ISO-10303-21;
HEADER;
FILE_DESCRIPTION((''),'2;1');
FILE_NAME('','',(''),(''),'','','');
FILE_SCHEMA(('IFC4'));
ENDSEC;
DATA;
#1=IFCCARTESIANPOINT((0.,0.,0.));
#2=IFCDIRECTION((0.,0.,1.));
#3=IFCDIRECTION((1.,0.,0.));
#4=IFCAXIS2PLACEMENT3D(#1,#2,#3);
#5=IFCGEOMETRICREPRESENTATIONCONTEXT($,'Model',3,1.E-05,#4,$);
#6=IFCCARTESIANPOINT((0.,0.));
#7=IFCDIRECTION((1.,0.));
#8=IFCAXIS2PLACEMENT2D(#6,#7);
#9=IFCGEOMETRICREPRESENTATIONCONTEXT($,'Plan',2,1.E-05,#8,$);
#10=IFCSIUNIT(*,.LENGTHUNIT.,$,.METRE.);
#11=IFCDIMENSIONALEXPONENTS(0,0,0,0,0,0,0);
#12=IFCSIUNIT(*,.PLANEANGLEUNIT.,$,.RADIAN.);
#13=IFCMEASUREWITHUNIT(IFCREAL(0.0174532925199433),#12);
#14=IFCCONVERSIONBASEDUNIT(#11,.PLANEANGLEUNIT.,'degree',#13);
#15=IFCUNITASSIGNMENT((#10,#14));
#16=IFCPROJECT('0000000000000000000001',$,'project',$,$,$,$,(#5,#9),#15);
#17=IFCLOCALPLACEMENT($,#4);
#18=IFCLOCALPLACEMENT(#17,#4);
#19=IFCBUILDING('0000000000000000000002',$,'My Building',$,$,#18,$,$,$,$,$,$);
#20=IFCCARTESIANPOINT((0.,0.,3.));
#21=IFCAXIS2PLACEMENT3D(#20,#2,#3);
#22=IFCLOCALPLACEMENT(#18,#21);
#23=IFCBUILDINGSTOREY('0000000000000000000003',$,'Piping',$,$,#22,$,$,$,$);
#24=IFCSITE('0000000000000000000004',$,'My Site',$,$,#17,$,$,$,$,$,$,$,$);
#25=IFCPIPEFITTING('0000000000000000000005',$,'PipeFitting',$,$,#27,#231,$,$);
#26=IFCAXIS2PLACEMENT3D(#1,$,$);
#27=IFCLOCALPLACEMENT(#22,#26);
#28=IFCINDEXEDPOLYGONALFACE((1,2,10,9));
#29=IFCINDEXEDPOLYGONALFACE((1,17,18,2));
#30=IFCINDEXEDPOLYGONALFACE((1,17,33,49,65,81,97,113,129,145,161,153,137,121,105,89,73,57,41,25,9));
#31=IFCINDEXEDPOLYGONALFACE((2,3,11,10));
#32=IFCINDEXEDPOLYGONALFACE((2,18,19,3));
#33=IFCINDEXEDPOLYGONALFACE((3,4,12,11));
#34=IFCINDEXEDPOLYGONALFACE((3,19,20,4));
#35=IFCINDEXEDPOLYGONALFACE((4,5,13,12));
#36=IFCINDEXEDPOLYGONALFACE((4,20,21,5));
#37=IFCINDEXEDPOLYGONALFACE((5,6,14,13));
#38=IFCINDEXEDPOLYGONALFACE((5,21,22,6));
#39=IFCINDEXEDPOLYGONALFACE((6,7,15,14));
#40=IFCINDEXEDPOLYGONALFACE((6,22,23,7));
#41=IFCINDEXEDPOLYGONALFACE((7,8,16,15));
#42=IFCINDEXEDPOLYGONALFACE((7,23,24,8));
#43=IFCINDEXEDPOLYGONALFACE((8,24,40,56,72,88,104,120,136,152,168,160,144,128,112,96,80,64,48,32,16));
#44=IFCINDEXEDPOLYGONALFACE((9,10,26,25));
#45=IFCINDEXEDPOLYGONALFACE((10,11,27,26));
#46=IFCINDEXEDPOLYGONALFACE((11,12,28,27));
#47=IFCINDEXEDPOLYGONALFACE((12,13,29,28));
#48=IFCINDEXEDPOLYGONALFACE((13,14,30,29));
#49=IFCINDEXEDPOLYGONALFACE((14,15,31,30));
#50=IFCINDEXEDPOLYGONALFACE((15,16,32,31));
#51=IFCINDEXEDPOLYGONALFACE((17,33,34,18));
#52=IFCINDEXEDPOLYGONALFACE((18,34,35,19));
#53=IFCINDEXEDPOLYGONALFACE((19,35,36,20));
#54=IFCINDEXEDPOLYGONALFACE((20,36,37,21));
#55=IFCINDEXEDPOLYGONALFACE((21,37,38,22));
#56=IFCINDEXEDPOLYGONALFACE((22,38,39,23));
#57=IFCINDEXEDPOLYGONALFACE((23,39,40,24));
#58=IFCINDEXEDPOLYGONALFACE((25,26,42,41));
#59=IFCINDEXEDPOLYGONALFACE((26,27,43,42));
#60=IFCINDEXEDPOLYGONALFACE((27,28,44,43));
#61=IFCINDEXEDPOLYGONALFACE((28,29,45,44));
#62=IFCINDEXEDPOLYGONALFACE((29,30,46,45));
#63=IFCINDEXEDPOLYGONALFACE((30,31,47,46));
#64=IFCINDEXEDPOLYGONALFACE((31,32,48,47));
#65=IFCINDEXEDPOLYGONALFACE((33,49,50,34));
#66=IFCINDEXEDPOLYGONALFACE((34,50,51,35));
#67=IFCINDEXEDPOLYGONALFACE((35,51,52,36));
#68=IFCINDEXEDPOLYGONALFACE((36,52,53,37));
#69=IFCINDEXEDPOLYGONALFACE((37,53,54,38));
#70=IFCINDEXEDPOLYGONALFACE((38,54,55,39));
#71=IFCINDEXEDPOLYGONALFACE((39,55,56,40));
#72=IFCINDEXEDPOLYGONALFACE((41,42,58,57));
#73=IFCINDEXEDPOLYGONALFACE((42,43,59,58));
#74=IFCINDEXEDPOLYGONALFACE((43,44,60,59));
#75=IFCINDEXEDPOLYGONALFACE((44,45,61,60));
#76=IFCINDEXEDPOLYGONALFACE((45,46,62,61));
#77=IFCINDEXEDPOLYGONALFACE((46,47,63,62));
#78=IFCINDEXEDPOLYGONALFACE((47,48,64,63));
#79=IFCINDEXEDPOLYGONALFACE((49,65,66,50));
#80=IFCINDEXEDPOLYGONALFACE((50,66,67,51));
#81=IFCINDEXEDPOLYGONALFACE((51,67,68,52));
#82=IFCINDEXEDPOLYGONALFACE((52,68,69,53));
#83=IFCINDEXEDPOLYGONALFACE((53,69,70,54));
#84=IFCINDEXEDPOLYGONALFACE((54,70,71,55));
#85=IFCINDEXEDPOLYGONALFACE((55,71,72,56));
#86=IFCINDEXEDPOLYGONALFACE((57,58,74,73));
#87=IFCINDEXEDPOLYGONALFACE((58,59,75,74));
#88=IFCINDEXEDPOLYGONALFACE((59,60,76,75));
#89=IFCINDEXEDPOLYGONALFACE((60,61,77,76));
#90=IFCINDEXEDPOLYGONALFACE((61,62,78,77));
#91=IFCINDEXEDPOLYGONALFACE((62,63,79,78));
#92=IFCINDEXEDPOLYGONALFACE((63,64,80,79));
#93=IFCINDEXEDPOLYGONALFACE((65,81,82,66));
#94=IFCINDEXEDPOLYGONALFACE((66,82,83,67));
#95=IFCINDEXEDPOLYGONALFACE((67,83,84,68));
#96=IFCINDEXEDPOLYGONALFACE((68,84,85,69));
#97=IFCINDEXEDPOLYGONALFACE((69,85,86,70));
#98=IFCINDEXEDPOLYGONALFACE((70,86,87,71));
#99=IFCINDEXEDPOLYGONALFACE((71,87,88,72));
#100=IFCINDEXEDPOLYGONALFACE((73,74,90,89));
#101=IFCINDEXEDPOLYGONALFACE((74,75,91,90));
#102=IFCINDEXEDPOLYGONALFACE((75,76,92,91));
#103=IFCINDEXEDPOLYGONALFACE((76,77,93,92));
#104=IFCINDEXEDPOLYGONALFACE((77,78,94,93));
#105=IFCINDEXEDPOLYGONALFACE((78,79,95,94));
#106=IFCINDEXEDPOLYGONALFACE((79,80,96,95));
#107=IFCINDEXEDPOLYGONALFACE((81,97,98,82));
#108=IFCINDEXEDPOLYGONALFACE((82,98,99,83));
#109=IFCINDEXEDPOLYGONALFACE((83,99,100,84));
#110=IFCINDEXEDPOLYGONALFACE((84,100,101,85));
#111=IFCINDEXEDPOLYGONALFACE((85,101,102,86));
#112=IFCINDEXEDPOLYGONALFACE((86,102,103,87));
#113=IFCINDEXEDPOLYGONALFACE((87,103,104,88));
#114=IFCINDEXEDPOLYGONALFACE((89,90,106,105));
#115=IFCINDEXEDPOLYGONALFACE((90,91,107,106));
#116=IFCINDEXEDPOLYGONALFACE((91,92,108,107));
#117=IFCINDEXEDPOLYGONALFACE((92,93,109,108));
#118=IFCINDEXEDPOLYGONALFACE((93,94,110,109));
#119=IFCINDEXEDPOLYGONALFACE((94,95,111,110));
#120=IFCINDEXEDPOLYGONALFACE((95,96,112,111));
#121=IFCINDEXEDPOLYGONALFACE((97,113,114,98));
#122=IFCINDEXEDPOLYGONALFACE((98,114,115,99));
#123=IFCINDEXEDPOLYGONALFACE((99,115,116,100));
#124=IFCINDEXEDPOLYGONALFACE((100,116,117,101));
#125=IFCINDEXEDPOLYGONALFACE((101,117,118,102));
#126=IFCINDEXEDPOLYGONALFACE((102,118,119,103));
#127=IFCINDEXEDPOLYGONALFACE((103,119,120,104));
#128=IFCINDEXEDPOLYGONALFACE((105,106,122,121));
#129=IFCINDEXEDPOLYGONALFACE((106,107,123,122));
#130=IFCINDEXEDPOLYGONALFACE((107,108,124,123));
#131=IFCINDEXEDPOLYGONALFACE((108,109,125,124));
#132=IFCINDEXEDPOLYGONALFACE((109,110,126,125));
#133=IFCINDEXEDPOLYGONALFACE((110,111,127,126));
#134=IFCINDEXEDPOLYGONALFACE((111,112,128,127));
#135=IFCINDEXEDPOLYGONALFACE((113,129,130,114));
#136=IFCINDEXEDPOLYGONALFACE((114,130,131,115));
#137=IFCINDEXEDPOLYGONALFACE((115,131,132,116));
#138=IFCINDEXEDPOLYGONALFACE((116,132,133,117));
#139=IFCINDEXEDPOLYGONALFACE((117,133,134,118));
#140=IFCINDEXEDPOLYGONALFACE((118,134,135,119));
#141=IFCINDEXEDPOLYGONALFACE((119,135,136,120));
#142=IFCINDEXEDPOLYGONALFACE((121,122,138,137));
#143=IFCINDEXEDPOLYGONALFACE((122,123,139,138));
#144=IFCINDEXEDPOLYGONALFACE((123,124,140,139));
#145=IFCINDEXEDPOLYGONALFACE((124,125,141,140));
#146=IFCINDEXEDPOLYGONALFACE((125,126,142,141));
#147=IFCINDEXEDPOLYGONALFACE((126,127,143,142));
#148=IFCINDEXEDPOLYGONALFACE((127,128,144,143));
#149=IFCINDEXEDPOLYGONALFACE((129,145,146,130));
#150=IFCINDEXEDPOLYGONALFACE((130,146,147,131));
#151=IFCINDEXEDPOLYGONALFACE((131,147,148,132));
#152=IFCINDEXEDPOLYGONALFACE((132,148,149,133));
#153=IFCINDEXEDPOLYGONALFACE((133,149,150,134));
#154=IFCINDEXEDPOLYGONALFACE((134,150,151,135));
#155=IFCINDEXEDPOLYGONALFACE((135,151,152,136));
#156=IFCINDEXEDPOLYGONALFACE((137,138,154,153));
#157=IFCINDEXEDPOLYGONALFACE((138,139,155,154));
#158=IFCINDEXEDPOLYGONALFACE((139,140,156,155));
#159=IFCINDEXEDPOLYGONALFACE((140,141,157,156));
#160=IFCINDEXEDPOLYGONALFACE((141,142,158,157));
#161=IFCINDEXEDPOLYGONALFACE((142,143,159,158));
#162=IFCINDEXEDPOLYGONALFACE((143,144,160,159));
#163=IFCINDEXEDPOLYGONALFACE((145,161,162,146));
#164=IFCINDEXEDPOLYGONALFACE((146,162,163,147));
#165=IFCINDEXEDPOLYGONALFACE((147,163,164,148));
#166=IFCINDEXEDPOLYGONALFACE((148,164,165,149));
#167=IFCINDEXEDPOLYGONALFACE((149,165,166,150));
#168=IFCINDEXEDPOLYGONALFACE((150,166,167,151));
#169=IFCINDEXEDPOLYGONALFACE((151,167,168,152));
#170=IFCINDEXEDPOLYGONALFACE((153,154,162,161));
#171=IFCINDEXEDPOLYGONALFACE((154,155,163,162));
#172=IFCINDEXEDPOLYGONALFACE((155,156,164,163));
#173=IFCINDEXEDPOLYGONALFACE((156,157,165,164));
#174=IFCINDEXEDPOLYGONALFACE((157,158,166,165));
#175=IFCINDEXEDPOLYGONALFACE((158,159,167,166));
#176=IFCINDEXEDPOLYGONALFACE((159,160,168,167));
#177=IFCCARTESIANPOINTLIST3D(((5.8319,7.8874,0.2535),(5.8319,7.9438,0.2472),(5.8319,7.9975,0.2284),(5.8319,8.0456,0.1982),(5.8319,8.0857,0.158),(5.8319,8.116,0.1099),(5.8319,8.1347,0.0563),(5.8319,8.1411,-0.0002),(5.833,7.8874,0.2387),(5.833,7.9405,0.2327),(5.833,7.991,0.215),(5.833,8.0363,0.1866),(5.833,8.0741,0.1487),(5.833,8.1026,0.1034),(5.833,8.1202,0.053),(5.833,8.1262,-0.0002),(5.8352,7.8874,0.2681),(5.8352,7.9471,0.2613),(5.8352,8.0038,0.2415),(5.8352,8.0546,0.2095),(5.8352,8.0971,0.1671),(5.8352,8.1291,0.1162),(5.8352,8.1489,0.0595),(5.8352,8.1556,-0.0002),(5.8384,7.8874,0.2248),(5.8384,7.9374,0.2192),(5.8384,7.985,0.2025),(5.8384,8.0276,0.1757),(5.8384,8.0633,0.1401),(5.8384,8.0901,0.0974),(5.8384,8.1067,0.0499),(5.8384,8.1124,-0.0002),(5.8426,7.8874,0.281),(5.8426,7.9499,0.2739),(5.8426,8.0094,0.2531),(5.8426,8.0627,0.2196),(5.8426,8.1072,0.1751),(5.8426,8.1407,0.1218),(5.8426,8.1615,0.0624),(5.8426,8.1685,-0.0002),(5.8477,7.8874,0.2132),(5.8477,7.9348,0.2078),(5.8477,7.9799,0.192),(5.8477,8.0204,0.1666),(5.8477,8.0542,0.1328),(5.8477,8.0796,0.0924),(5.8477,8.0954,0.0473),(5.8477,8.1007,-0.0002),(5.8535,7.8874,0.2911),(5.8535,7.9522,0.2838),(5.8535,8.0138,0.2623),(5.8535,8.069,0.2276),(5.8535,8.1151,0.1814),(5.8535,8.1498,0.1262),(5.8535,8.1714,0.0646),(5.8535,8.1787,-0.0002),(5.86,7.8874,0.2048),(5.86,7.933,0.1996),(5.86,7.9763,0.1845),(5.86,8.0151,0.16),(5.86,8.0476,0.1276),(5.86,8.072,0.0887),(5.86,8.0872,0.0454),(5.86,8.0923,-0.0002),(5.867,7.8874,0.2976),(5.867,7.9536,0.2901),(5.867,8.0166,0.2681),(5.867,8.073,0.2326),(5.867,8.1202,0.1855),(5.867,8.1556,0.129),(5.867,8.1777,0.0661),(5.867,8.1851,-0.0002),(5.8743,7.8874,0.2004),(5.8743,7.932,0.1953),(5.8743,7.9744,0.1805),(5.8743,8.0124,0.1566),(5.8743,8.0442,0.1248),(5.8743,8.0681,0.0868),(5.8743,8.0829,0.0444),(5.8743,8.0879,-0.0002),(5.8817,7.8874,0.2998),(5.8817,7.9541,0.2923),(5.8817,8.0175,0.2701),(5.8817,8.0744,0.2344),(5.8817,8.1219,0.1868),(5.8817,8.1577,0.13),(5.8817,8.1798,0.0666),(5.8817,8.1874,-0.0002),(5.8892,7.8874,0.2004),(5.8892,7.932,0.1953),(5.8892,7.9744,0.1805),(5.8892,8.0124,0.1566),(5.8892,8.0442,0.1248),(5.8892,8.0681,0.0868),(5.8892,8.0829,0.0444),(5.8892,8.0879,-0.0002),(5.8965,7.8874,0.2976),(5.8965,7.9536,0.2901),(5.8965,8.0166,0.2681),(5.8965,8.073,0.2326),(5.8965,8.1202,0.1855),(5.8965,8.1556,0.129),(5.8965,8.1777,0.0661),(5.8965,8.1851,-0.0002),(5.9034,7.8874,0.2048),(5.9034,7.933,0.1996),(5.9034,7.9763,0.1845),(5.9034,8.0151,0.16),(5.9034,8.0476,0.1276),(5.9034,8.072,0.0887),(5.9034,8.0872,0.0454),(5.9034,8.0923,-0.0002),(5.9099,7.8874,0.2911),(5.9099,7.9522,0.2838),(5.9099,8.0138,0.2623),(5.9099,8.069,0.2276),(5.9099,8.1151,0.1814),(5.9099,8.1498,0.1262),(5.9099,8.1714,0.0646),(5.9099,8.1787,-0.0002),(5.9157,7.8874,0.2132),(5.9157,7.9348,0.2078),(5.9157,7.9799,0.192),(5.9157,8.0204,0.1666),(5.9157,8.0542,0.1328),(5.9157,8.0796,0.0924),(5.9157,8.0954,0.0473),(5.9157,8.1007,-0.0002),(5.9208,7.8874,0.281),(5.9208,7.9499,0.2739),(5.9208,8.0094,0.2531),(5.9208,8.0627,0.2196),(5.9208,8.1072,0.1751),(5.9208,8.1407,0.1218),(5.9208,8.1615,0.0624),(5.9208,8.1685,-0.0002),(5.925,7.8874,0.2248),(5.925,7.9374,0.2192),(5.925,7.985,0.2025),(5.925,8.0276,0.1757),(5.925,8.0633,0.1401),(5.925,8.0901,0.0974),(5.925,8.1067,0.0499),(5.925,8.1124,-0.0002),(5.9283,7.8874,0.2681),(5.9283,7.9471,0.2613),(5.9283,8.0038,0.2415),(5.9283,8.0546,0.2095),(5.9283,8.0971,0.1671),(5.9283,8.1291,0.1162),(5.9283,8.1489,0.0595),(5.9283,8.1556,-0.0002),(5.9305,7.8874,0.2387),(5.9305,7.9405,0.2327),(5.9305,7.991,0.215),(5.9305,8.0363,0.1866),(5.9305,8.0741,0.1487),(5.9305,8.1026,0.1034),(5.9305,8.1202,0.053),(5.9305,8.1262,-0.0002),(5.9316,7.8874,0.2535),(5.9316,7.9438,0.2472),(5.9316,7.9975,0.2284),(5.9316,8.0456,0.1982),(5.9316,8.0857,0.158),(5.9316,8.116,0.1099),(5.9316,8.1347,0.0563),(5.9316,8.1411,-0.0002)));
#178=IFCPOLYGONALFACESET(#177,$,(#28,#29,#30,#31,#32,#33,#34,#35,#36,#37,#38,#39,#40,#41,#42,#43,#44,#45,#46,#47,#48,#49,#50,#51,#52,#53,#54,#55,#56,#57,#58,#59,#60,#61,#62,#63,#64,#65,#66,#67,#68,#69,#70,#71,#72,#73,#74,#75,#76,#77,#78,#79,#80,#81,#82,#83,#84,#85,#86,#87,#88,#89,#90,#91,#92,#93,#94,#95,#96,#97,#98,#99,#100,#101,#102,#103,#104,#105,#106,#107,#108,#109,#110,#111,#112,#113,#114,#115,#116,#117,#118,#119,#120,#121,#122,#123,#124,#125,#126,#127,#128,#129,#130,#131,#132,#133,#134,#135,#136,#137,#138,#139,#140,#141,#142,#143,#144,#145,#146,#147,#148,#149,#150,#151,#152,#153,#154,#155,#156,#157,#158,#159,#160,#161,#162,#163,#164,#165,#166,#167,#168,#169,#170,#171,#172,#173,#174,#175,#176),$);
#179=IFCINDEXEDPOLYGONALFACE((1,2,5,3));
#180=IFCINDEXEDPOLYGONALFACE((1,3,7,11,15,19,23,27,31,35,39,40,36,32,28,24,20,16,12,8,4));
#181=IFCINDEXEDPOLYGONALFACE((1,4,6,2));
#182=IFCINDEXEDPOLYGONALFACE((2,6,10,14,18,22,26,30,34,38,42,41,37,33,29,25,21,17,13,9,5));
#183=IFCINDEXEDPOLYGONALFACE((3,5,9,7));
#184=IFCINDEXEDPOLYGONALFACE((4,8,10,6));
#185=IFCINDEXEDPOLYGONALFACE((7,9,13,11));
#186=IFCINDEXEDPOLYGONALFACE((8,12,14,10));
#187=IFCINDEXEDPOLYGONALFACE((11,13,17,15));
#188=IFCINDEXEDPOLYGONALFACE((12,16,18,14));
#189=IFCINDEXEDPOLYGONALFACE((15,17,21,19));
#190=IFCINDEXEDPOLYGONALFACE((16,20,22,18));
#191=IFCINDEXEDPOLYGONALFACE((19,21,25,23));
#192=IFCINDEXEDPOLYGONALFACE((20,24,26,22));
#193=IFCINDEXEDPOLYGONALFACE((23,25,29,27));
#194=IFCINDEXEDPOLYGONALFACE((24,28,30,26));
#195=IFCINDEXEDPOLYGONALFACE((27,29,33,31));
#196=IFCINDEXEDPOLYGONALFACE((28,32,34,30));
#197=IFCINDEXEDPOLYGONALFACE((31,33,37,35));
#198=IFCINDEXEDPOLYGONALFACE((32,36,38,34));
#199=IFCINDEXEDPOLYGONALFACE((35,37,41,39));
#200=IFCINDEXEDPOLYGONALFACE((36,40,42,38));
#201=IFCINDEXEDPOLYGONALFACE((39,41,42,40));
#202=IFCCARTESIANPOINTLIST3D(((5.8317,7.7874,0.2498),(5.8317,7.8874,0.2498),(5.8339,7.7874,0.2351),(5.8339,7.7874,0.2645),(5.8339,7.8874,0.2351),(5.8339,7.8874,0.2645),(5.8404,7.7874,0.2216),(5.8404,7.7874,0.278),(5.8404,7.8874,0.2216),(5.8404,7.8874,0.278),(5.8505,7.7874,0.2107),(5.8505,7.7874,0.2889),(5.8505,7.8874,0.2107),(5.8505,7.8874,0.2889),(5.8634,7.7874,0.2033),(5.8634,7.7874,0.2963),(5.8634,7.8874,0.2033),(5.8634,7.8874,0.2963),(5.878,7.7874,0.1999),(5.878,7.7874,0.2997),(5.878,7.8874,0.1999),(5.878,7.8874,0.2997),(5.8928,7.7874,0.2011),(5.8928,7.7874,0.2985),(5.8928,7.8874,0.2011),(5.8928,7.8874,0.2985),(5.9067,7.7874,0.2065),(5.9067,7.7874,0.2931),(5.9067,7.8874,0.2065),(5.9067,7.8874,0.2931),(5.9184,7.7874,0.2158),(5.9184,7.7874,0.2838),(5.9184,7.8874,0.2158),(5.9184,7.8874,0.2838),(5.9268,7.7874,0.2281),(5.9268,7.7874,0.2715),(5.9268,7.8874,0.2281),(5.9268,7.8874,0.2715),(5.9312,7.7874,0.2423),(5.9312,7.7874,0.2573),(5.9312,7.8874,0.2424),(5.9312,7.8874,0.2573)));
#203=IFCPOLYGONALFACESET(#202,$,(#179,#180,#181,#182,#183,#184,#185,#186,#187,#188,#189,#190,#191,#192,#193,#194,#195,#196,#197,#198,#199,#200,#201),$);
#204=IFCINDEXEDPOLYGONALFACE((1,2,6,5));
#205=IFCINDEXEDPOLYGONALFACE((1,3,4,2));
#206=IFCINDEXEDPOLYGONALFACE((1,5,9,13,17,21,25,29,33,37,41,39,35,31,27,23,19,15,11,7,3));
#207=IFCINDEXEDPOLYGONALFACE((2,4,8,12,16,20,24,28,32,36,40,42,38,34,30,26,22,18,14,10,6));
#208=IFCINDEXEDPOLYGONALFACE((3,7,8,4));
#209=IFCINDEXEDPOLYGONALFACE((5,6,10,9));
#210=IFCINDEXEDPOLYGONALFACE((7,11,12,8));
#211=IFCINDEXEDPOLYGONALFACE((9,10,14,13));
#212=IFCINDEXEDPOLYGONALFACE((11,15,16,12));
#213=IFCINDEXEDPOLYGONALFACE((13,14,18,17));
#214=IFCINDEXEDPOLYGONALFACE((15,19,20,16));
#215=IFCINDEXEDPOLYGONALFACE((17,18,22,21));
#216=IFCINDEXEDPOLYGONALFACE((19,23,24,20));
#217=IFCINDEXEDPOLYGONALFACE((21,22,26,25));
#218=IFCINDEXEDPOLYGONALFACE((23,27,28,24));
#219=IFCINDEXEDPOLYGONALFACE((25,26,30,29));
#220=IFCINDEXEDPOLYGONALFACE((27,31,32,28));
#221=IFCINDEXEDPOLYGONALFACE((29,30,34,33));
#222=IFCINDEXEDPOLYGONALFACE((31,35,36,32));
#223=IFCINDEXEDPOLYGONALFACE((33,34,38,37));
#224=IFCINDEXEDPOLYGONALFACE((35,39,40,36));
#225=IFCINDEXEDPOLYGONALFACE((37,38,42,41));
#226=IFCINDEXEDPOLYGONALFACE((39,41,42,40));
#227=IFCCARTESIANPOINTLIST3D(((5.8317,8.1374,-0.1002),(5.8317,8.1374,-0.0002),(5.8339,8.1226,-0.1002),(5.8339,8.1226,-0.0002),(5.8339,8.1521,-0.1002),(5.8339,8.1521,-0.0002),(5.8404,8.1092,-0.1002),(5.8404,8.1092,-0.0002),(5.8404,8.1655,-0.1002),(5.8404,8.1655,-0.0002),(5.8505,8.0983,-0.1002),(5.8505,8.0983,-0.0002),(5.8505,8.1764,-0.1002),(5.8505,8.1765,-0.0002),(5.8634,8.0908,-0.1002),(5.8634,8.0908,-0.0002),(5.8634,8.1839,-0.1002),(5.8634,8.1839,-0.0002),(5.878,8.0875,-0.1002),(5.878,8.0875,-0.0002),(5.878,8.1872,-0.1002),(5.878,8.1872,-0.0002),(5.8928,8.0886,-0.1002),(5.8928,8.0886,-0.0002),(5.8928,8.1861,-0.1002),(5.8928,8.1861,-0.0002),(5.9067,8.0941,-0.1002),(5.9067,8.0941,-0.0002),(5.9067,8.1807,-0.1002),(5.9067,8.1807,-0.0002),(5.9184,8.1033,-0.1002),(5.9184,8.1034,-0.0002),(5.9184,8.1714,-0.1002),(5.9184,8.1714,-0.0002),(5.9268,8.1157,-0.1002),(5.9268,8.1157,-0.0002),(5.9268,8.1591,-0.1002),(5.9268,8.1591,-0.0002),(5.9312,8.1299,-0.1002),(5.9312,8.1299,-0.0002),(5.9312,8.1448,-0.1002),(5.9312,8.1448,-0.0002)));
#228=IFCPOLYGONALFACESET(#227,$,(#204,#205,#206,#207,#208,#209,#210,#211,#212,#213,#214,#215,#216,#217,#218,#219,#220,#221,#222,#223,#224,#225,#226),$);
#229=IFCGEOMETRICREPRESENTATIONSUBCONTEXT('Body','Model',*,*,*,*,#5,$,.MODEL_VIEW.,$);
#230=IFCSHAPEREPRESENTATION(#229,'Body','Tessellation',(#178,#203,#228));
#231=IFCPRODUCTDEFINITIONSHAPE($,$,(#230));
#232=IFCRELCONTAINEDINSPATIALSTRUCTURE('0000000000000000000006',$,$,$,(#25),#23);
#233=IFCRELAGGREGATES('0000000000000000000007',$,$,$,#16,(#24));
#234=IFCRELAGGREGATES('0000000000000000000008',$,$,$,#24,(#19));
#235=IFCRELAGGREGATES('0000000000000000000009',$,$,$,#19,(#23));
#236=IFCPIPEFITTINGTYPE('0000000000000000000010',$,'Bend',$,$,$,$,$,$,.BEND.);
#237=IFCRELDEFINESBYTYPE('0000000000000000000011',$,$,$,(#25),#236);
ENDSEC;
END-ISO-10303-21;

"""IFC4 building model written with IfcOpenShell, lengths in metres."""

from ifc_helpers import new_model, entity, si_unit, converted_unit, frame, origin_with_axes, origin_2d_with_axis, place, context, subcontext, project, spatial, circle, extrude, source, transform, mapped, type_object, type_shapes, element, save


model = new_model("IFC4")

# Units and contexts
model_context = context("Model", 3, precision=1e-05, world=origin_with_axes())
plan_context = context("Plan", 2, precision=1e-05, world=origin_2d_with_axis())
body_context = subcontext(model_context, "Body", "Model", "MODEL_VIEW")
ifc_project = project(units=[si_unit("LENGTHUNIT", "METRE"), converted_unit("PLANEANGLEUNIT", "degree", entity("IfcReal", 0.0174532925199433), si_unit("PLANEANGLEUNIT", "RADIAN"), dimensions=[0, 0, 0, 0, 0, 0, 0])], contexts=[model_context, plan_context])

# Site, building, storey
site_placement = place(None, origin_with_axes())
site = spatial("IfcSite", under=ifc_project, at=site_placement, Name="My Site")
building_placement = place(site_placement, origin_with_axes())
building = spatial("IfcBuilding", under=site, at=building_placement, Name="My Building")
storey_placement = place(building_placement, frame((0.0, 0.0, 3.0), z_axis=(0.0, 0.0, 1.0), x_axis=(1.0, 0.0, 0.0)))
storey = spatial("IfcBuildingStorey", under=building, at=storey_placement, Name="Piping")

# Pipe fitting
pipe_fitting_type_1 = type_object("IfcPipeFittingType", Name="Bend", PredefinedType="BEND")
shared_shape = source(origin_with_axes(), body_context, "Body", "SolidModel", [
    entity("IfcSweptDiskSolid", entity("IfcIndexedPolyCurve", entity("IfcCartesianPointList3D", [[0.0, 0.0, 0.1], [0.0, -0.0732, 0.2768], [0.0, -0.25, 0.35]]), [entity("IfcArcIndex", [1, 2, 3])]), 0.05),
    extrude(circle(Radius=0.05), origin_with_axes(), (0.0, 0.0, 1.0), 0.1),
    extrude(circle(Radius=0.05), frame((0.0, -0.25, 0.35), z_axis=(0.0, -1.0, -0.00003), x_axis=(1.0, 0.0, 0.0)), (0.0, 0.0, 1.0), 0.1),
])
type_shapes(pipe_fitting_type_1, [shared_shape])
for number, where, z_axis, x_axis, name in (
    (1, (5.8817, 7.7874, 0.2498), (0.0, 1.0, 0.000008), (-1.0, 0.0, 0.0), "PipeFitting"),
):
    element("IfcPipeFitting", number, at=place(storey_placement, frame(where, z_axis=z_axis, x_axis=x_axis)), inside=storey, type_object=pipe_fitting_type_1, Name=name, context=body_context, shape_type="MappedRepresentation", body=[
        mapped(shared_shape, transform((0.0, 0.0, 0.0), x_axis=(1.0, 0.0, 0.0), y_axis=(0.0, 1.0, 0.0), z_axis=(0.0, 0.0, 1.0), scale=1.0)),
    ])

save(model, "model.ifc")
